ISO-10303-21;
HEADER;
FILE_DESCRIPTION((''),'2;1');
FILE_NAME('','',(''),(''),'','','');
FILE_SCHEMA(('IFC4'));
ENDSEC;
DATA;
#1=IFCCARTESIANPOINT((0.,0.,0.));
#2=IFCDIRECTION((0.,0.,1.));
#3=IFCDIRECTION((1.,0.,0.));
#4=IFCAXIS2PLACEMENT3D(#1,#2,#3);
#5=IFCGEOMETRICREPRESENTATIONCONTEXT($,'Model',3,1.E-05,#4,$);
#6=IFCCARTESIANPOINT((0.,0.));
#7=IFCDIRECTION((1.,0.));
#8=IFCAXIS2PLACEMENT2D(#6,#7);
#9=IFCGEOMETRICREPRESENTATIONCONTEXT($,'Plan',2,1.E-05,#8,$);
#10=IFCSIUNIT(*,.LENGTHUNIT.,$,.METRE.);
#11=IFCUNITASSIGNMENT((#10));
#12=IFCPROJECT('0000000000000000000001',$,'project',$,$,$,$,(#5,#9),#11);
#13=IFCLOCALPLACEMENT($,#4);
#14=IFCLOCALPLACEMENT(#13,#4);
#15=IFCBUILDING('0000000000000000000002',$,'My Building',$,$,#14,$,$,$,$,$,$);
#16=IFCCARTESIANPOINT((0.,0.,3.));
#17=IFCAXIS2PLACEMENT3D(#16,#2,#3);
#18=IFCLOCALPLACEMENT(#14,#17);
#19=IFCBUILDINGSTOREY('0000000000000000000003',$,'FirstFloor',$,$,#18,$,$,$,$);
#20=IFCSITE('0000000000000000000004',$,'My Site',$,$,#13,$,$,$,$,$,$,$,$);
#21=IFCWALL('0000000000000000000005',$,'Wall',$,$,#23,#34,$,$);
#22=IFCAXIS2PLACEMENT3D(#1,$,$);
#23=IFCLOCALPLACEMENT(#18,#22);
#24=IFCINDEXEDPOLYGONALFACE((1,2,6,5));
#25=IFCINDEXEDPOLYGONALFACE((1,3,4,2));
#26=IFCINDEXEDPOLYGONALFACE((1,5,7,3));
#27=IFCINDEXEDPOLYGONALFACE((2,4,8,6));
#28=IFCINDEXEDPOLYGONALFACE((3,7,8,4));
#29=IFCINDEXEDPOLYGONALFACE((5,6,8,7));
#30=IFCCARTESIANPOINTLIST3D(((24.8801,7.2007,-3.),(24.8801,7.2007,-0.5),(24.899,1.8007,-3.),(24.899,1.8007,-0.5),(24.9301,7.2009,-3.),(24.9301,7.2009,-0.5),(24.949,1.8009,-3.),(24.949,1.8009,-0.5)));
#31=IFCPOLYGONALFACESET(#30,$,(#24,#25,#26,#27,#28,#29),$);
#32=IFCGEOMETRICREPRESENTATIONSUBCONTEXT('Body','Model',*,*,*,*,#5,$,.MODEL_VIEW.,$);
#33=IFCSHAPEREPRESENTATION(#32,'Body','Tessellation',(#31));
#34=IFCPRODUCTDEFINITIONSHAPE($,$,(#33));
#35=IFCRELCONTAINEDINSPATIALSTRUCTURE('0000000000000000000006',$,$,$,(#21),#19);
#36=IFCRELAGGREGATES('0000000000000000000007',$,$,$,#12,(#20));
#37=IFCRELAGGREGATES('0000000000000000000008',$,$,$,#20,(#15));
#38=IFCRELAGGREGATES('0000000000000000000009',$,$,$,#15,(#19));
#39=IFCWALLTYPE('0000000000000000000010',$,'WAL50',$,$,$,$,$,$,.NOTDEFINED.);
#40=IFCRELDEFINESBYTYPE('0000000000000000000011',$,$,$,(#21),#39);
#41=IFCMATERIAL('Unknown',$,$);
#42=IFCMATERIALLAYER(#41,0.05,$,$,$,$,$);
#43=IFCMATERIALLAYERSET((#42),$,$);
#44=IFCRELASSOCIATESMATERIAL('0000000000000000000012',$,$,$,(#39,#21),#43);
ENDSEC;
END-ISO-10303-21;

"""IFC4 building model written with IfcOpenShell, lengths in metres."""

from ifc_helpers import new_model, si_unit, frame, origin_with_axes, origin_2d_with_axis, place, context, subcontext, project, spatial, line, indexed_curve, outline, extrude, material, layer, layer_set, layer_usage, type_object, element, save


model = new_model("IFC4")

# Units and contexts
model_context = context("Model", 3, precision=1e-05, world=origin_with_axes())
plan_context = context("Plan", 2, precision=1e-05, world=origin_2d_with_axis())
body_context_1 = subcontext(model_context, "Body", "Model", "MODEL_VIEW")
ifc_project = project(units=[si_unit("LENGTHUNIT", "METRE")], contexts=[model_context, plan_context])

# Site, building, storey
site_placement = place(None, origin_with_axes())
site = spatial("IfcSite", under=ifc_project, at=site_placement, Name="My Site")
building_placement = place(site_placement, origin_with_axes())
building = spatial("IfcBuilding", under=site, at=building_placement, Name="My Building")
storey_placement = place(building_placement, frame((0.0, 0.0, 3.0), z_axis=(0.0, 0.0, 1.0), x_axis=(1.0, 0.0, 0.0)))
storey = spatial("IfcBuildingStorey", under=building, at=storey_placement, Name="FirstFloor")

# Wall
ifc_material = material(Name="Unknown")
ifc_layer_1 = layer(ifc_material, 0.05)
ifc_layer_set_1 = layer_set([ifc_layer_1])
ifc_layer_usage_1 = layer_usage(ifc_layer_set_1, "AXIS2", "POSITIVE", 0.0)
wall_type_1 = type_object("IfcWallType", Name="WAL50", PredefinedType="NOTDEFINED", material=ifc_layer_set_1)
wall_1_placement = place(storey_placement, frame((24.8801, 7.2007, -3.0), z_axis=(0.0, 0.0, 1.0), x_axis=(0.00349, -0.999994, 0.0)))
element("IfcWall", 1, at=wall_1_placement, inside=storey, type_object=wall_type_1, material=ifc_layer_usage_1, Name="Wall", context=body_context_1, shape_type="SweptSolid", body=[
    extrude(outline(indexed_curve([(0.0, 0.0), (0.0, 0.05), (5.4, 0.05), (5.4, 0.0)], segments=[line(1, 2, 3, 4, 1)])), origin_with_axes(), (0.0, 0.0, 1.0), 2.5),
])

save(model, "model.ifc")
